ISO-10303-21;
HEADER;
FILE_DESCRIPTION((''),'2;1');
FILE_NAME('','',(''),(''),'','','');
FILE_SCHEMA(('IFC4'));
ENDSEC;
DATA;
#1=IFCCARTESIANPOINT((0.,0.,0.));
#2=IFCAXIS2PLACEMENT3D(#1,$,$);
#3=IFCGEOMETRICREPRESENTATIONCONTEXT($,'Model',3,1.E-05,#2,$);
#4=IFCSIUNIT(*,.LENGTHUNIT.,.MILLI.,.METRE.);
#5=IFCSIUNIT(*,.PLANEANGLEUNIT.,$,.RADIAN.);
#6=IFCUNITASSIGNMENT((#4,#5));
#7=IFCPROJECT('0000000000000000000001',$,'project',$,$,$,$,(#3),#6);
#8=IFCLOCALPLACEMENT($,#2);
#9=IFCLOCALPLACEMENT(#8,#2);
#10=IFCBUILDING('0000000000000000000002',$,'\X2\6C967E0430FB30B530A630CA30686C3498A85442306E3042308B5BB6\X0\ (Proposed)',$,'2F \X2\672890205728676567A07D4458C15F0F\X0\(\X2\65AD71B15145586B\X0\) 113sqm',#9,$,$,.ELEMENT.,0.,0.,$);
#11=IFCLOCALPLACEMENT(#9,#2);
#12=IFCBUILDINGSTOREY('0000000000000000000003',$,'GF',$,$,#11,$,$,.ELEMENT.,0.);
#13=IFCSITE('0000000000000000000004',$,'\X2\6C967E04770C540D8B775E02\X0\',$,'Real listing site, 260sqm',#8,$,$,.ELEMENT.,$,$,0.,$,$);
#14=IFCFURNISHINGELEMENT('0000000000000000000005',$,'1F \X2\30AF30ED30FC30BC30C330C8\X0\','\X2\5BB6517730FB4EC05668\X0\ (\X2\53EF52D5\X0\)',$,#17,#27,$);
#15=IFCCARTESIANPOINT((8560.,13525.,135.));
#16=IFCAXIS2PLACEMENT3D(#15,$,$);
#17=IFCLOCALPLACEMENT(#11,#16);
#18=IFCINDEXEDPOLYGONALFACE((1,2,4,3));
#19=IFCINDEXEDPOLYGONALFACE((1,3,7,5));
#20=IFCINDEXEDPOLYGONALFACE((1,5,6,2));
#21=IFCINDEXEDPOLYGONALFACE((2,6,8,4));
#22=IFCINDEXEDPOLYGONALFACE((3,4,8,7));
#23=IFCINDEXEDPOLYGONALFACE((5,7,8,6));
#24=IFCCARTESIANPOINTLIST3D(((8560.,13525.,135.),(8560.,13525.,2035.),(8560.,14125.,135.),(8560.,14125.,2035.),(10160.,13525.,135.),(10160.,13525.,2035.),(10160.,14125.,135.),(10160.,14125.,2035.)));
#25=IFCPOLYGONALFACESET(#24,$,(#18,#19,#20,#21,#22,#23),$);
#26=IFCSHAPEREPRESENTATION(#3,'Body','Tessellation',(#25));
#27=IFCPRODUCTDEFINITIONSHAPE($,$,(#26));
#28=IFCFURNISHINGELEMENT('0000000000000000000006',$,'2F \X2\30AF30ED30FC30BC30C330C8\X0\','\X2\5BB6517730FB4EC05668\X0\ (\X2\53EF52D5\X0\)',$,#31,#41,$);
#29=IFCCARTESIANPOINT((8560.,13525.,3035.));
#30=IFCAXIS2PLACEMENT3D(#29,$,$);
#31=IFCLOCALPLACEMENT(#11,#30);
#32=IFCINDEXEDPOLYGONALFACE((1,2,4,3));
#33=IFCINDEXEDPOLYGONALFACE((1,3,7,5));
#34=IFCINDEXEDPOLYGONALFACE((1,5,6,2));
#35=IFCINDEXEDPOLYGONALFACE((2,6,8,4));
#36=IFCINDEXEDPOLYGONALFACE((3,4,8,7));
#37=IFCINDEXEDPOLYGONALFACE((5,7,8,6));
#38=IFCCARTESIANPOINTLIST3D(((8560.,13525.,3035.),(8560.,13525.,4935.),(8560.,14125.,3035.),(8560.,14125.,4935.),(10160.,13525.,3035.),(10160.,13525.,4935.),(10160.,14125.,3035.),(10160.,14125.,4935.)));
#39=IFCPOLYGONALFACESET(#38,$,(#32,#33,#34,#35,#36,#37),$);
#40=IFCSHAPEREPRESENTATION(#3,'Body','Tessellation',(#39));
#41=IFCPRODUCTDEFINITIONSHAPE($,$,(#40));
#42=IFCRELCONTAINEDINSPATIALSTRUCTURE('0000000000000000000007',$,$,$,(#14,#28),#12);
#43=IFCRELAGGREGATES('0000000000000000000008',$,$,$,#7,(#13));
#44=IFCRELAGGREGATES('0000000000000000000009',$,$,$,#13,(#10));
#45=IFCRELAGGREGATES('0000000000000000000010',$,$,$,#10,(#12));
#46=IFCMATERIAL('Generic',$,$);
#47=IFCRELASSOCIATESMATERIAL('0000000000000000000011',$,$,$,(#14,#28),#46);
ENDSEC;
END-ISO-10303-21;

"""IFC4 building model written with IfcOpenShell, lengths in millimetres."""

from ifc_helpers import new_model, si_unit, frame, frame_2d, origin, place, context, project, spatial, rectangle, extrude, material, element, save


model = new_model("IFC4")

# Units and contexts
model_context = context("Model", 3, precision=1e-05, world=origin())
ifc_project = project(units=[si_unit("LENGTHUNIT", "METRE", prefix="MILLI"), si_unit("PLANEANGLEUNIT", "RADIAN")], contexts=[model_context])

# Site, building, storey
site_placement = place(None, origin())
site = spatial("IfcSite", under=ifc_project, at=site_placement, Name="沖縄県名護市", ObjectType="Real listing site, 260sqm", CompositionType="ELEMENT", RefElevation=0.0)
building_placement = place(site_placement, origin())
building = spatial("IfcBuilding", under=site, at=building_placement, Name="沖縄・サウナと水風呂のある家 (Proposed)", ObjectType="2F 木造在来枠組壁式(断熱充填) 113sqm", CompositionType="ELEMENT", ElevationOfRefHeight=0.0, ElevationOfTerrain=0.0)
storey_placement = place(building_placement, origin())
storey = spatial("IfcBuildingStorey", under=building, at=storey_placement, Name="GF", CompositionType="ELEMENT", Elevation=0.0)

# Shared definitions
ifc_material_1 = material(Name="Generic")

# Furnishing elements
furnishing_1_placement = place(storey_placement, frame((8560.0, 13525.0, 135.0)))
element("IfcFurnishingElement", 1, at=furnishing_1_placement, inside=storey, material=ifc_material_1, Name="1F クローゼット", Description="家具・什器 (可動)", context=model_context, shape_type="SweptSolid", body=[
    extrude(rectangle(XDim=1600.0, YDim=600.0, at=frame_2d((800.0, 300.0))), frame((8560.0, 13525.0, 135.0)), (0.0, 0.0, 1.0), 1900.0),
])
furnishing_2_placement = place(storey_placement, frame((8560.0, 13525.0, 3035.0)))
element("IfcFurnishingElement", 2, at=furnishing_2_placement, inside=storey, material=ifc_material_1, Name="2F クローゼット", Description="家具・什器 (可動)", context=model_context, shape_type="SweptSolid", body=[
    extrude(rectangle(XDim=1600.0, YDim=600.0, at=frame_2d((800.0, 300.0))), frame((8560.0, 13525.0, 3035.0)), (0.0, 0.0, 1.0), 1900.0),
])

save(model, "model.ifc")
